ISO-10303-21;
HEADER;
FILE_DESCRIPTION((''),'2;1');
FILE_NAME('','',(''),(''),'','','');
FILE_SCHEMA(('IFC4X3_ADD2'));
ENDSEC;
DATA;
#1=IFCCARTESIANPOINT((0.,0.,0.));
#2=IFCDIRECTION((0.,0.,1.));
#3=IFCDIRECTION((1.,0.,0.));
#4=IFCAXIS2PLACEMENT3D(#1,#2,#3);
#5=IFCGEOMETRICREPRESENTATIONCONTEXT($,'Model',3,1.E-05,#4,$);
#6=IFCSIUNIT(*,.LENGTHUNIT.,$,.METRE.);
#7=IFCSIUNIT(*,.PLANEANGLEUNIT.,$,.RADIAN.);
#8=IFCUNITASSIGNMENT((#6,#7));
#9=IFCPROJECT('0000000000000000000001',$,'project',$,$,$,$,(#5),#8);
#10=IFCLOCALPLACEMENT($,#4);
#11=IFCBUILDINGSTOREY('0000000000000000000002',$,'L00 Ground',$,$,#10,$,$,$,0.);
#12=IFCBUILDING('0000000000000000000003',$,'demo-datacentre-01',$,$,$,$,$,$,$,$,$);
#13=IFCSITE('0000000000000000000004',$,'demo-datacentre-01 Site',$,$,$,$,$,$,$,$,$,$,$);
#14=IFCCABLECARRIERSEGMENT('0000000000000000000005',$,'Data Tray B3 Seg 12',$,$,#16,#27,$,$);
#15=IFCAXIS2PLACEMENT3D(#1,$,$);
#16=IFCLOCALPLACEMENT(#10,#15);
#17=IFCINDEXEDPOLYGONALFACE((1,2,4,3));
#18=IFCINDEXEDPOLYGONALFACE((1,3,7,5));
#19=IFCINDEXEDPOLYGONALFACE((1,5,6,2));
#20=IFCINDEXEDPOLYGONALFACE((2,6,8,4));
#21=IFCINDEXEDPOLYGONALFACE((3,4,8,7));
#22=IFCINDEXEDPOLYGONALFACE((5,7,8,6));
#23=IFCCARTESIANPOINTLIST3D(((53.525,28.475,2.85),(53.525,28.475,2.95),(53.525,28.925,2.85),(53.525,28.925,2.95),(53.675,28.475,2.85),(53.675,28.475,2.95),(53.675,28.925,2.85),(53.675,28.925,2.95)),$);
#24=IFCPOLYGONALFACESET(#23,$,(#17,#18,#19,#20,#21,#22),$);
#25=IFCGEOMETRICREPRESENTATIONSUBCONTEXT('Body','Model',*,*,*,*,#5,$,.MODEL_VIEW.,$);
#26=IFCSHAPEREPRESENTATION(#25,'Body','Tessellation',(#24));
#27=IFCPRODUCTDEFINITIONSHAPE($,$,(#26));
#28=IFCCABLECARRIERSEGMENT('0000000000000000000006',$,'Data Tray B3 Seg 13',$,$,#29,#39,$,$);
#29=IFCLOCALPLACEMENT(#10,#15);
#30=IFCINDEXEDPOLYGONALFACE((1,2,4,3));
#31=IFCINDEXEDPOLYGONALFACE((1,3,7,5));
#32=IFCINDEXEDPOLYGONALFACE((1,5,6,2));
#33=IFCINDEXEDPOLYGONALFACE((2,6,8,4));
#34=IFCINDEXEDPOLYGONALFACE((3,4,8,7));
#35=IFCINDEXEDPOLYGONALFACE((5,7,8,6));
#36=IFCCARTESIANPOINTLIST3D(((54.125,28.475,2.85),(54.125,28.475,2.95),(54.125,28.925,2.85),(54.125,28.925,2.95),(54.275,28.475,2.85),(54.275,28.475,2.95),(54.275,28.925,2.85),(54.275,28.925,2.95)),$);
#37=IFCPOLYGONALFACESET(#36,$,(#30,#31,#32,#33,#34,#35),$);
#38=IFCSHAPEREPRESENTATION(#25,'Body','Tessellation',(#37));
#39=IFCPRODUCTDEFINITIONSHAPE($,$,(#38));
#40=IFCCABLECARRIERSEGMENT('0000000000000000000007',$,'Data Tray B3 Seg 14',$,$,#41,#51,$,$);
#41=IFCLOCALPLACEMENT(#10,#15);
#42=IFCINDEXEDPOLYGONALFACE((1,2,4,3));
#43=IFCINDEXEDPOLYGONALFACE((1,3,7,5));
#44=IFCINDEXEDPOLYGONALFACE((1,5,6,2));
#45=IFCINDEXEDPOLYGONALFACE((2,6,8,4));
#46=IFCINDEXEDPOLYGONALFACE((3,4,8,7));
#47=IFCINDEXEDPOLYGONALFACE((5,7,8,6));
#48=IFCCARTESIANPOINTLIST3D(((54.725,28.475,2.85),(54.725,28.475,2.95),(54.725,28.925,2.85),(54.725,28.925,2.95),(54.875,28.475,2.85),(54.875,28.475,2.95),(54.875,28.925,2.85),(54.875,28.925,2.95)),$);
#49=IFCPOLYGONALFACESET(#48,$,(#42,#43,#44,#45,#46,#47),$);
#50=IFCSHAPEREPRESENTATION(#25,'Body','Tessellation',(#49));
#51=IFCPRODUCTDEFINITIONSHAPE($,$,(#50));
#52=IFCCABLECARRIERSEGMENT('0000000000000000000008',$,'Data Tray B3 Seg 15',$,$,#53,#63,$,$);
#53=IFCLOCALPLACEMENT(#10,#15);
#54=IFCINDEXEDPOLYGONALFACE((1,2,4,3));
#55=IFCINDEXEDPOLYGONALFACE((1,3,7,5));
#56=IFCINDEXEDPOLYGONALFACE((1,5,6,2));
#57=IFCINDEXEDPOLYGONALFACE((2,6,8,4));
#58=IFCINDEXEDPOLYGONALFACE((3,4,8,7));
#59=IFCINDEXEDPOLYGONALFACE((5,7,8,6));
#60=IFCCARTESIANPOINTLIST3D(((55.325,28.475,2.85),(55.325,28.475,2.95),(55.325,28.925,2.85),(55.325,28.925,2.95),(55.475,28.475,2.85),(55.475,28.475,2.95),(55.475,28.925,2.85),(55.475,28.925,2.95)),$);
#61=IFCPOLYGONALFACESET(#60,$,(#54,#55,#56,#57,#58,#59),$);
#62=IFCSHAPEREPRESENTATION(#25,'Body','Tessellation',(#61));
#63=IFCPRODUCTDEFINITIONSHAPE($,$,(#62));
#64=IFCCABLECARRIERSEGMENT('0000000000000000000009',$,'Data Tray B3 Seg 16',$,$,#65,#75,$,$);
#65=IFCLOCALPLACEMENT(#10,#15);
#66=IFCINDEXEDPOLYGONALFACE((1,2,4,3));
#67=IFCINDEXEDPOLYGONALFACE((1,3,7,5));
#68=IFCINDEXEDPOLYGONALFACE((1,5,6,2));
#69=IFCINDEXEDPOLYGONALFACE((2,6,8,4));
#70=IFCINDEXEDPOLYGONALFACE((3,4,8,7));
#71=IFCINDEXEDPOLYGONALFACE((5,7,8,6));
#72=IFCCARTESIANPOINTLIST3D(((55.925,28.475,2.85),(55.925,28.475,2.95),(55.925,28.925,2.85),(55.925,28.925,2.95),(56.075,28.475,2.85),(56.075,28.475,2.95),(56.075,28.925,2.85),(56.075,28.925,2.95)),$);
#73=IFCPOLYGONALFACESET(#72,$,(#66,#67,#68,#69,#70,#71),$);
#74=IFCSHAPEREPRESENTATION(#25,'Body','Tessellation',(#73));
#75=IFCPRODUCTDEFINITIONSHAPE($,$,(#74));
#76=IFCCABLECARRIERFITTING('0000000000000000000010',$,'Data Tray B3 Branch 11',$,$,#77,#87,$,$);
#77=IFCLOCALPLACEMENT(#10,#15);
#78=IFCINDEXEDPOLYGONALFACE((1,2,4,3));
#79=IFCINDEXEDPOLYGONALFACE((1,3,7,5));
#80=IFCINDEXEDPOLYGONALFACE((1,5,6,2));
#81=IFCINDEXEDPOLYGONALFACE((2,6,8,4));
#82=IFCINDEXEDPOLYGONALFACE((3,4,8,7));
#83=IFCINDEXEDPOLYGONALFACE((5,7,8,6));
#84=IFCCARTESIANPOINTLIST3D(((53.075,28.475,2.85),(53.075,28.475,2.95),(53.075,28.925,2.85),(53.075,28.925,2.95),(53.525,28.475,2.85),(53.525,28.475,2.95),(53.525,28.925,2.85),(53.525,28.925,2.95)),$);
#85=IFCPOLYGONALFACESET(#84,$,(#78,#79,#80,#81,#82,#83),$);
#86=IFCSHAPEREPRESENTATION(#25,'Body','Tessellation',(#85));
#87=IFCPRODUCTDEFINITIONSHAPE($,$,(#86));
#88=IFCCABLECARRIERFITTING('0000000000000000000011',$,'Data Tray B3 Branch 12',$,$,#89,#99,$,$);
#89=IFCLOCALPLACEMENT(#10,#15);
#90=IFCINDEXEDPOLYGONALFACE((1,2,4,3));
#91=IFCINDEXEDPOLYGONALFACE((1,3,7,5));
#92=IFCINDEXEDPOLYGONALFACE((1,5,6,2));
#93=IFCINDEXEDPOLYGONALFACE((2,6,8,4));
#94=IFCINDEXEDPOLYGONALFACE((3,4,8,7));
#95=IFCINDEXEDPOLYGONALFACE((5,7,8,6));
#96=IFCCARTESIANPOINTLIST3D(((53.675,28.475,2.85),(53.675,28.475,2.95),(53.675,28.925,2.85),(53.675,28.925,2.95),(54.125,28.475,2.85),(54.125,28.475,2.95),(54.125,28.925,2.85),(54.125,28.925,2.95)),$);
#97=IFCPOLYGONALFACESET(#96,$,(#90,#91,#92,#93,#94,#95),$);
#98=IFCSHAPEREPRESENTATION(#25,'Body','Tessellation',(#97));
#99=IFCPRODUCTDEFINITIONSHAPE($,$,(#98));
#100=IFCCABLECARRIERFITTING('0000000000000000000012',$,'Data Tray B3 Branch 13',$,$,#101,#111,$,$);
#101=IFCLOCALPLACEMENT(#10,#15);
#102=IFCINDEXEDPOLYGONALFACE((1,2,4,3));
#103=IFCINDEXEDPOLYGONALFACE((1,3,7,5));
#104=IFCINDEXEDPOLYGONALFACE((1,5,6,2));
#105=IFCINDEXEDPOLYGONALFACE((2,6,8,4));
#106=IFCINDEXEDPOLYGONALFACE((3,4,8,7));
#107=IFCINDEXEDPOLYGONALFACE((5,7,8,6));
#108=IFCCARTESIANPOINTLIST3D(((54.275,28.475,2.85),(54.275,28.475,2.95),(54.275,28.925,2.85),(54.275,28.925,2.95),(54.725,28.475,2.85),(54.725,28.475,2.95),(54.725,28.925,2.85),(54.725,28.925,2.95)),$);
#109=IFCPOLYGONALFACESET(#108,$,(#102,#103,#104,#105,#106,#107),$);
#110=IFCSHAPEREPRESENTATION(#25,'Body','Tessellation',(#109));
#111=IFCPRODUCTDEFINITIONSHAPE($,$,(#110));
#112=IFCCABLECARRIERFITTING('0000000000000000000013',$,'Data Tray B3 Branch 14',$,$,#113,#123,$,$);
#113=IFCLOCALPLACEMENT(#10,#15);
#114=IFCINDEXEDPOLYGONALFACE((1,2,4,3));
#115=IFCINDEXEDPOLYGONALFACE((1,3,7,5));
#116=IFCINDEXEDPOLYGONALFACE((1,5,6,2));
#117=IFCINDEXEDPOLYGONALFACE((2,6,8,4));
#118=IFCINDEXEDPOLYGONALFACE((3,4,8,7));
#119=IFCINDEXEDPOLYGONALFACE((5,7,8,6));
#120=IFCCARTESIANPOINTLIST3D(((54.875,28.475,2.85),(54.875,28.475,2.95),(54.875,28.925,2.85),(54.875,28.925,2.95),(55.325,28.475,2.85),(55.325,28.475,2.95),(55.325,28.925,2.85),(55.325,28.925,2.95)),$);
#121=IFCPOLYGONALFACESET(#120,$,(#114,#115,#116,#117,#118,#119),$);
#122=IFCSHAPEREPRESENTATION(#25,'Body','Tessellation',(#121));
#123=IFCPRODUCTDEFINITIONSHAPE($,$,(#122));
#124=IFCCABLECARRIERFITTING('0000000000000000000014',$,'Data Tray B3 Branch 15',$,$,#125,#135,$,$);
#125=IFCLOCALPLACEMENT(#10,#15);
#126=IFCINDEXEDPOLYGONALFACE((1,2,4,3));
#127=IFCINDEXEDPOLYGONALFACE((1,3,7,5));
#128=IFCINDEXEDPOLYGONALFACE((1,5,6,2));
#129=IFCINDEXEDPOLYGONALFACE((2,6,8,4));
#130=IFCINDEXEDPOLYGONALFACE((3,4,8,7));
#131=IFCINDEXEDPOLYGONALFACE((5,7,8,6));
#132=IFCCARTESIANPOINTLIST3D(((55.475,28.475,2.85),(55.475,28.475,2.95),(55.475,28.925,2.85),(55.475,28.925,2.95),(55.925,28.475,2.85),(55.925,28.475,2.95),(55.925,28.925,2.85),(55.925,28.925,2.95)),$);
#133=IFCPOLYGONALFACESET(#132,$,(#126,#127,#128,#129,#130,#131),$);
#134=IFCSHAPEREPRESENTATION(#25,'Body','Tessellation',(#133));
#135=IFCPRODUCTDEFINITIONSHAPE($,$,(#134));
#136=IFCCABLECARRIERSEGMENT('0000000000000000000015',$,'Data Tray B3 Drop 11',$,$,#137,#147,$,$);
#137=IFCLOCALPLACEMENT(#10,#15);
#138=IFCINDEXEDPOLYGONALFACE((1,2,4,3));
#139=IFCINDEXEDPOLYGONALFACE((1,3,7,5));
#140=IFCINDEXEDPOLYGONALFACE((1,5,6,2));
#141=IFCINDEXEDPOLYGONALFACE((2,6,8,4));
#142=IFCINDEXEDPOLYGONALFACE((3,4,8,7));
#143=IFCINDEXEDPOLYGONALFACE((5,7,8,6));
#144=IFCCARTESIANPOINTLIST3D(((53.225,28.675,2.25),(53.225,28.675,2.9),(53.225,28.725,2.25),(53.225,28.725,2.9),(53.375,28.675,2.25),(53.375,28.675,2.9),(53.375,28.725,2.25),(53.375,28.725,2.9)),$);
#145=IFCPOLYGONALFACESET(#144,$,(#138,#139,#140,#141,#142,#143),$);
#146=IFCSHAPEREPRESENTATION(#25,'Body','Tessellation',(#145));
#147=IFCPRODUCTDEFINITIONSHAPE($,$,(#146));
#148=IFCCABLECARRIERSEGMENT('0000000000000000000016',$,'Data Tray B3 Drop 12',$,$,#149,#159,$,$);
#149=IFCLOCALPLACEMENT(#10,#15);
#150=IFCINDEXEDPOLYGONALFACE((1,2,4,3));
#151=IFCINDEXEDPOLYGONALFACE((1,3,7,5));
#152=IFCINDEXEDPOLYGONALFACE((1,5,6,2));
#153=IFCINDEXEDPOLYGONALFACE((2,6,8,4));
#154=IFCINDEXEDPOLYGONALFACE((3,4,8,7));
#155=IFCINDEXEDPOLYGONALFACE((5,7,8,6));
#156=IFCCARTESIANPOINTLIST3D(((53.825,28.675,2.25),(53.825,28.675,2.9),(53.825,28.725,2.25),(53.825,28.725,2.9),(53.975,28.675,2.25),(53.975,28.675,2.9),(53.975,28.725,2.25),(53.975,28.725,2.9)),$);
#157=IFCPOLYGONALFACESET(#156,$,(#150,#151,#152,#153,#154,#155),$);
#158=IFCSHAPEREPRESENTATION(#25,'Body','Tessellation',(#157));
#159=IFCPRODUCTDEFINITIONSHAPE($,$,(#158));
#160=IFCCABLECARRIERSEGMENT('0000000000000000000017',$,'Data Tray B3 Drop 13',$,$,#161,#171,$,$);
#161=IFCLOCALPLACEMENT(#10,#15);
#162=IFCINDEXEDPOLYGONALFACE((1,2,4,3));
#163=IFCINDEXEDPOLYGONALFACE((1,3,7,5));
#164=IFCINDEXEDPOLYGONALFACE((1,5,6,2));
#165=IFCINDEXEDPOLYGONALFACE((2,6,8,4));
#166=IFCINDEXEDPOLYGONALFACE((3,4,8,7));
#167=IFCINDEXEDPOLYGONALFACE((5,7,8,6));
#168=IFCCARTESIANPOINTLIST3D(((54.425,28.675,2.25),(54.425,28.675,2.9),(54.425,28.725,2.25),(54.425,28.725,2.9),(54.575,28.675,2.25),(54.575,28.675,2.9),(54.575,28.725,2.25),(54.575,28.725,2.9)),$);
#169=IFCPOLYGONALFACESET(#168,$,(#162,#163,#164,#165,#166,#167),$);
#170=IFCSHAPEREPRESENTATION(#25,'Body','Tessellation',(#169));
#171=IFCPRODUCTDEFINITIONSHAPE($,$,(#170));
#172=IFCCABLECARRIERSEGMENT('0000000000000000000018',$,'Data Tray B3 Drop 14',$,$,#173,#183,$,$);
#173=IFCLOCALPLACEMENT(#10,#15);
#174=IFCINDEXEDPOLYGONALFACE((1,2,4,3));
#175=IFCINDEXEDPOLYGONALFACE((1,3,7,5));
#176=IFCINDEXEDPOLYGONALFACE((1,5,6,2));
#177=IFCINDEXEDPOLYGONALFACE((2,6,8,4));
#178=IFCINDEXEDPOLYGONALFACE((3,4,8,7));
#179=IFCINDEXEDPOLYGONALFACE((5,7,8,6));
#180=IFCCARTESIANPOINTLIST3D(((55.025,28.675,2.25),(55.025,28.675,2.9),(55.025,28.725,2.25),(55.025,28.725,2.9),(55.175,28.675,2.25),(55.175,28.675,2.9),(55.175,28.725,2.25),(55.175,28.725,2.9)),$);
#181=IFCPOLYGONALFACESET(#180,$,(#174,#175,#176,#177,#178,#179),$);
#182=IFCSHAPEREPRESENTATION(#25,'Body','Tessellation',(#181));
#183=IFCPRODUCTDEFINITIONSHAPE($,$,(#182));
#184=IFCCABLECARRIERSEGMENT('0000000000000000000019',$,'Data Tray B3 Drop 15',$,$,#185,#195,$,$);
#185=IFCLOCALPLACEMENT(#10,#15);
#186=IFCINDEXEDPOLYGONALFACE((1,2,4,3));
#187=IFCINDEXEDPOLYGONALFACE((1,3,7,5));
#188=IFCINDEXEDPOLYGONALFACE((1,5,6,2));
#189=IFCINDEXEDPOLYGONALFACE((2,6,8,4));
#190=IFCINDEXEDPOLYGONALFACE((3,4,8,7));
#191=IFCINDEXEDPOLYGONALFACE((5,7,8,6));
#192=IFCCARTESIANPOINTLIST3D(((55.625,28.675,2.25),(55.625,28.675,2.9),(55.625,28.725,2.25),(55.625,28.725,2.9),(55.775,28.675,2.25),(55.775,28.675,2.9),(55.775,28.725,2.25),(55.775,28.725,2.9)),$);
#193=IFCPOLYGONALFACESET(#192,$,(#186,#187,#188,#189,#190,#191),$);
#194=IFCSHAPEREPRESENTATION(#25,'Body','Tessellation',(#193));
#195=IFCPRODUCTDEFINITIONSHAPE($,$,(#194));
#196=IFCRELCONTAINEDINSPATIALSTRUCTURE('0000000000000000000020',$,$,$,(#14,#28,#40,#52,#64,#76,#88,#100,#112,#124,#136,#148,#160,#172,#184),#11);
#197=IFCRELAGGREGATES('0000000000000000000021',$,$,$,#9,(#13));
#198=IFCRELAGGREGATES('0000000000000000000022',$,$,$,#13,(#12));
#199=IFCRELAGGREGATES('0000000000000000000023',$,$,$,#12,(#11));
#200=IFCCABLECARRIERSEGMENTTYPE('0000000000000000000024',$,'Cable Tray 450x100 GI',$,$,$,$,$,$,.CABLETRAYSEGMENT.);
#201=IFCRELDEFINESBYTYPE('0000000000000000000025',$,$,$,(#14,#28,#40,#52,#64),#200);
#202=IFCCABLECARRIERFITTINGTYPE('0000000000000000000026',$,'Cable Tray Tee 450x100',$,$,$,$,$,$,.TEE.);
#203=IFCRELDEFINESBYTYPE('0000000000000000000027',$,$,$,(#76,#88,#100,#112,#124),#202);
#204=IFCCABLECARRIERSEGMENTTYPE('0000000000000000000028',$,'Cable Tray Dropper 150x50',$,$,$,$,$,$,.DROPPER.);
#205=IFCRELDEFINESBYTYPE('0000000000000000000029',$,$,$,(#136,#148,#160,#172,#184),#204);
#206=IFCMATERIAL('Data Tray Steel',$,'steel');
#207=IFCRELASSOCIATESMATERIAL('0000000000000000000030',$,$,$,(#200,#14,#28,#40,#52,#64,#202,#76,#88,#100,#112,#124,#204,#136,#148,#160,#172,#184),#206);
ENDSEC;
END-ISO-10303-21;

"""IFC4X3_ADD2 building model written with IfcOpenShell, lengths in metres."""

from ifc_helpers import new_model, si_unit, frame, origin_with_axes, place, context, subcontext, project, spatial, rectangle, extrude, material, type_object, element, save


model = new_model("IFC4X3_ADD2")

# Units and contexts
model_context = context("Model", 3, precision=1e-05, world=origin_with_axes())
body_context = subcontext(model_context, "Body", "Model", "MODEL_VIEW")
ifc_project = project(units=[si_unit("LENGTHUNIT", "METRE"), si_unit("PLANEANGLEUNIT", "RADIAN")], contexts=[model_context])

# Site, building, storey
site = spatial("IfcSite", under=ifc_project, Name="demo-datacentre-01 Site")
building = spatial("IfcBuilding", under=site, Name="demo-datacentre-01")
storey_placement = place(None, origin_with_axes())
storey = spatial("IfcBuildingStorey", under=building, at=storey_placement, Name="L00 Ground", Elevation=0.0)

# Cable carrier segments
ifc_material_1 = material(Name="Data Tray Steel", Category="steel")
cable_carrier_segment_type_1 = type_object("IfcCableCarrierSegmentType", Name="Cable Tray 450x100 GI", PredefinedType="CABLETRAYSEGMENT", material=ifc_material_1)
for number, where, z_axis, x_axis, name in (
    (1, (53.525, 28.7, 2.9), (1.0, 0.0, 0.0), (0.0, 1.0, 0.0), "Data Tray B3 Seg 12"),
    (2, (54.125, 28.7, 2.9), (1.0, 0.0, 0.0), (0.0, 1.0, 0.0), "Data Tray B3 Seg 13"),
):
    element("IfcCableCarrierSegment", number, at=place(storey_placement, frame(where, z_axis=z_axis, x_axis=x_axis)), inside=storey, type_object=cable_carrier_segment_type_1, material=ifc_material_1, Name=name, context=body_context, shape_type="SweptSolid", body=[
        extrude(rectangle(XDim=0.45, YDim=0.1), origin_with_axes(), (0.0, 0.0, 1.0), 0.15),
    ])
cable_carrier_segment_placement = place(storey_placement, frame((54.725, 28.7, 2.9), z_axis=(1.0, 0.0, 0.0), x_axis=(0.0, 1.0, 0.0)))
element("IfcCableCarrierSegment", 3, at=cable_carrier_segment_placement, inside=storey, type_object=cable_carrier_segment_type_1, material=ifc_material_1, Name="Data Tray B3 Seg 14", context=body_context, shape_type="SweptSolid", body=[
    extrude(rectangle(XDim=0.45, YDim=0.1), origin_with_axes(), (0.0, 0.0, 1.0), 0.15),
])
for number, where, z_axis, x_axis, name in (
    (4, (55.325, 28.7, 2.9), (1.0, 0.0, 0.0), (0.0, 1.0, 0.0), "Data Tray B3 Seg 15"),
    (5, (55.925, 28.7, 2.9), (1.0, 0.0, 0.0), (0.0, 1.0, 0.0), "Data Tray B3 Seg 16"),
):
    element("IfcCableCarrierSegment", number, at=place(storey_placement, frame(where, z_axis=z_axis, x_axis=x_axis)), inside=storey, type_object=cable_carrier_segment_type_1, material=ifc_material_1, Name=name, context=body_context, shape_type="SweptSolid", body=[
        extrude(rectangle(XDim=0.45, YDim=0.1), origin_with_axes(), (0.0, 0.0, 1.0), 0.15),
    ])

# Cable carrier fittings
cable_carrier_fitting_type = type_object("IfcCableCarrierFittingType", Name="Cable Tray Tee 450x100", PredefinedType="TEE", material=ifc_material_1)
for number, where, z_axis, x_axis, name in (
    (6, (53.3, 28.7, 2.85), (0.0, 0.0, 1.0), (1.0, 0.0, 0.0), "Data Tray B3 Branch 11"),
    (7, (53.9, 28.7, 2.85), (0.0, 0.0, 1.0), (1.0, 0.0, 0.0), "Data Tray B3 Branch 12"),
    (8, (54.5, 28.7, 2.85), (0.0, 0.0, 1.0), (1.0, 0.0, 0.0), "Data Tray B3 Branch 13"),
    (9, (55.1, 28.7, 2.85), (0.0, 0.0, 1.0), (1.0, 0.0, 0.0), "Data Tray B3 Branch 14"),
    (10, (55.7, 28.7, 2.85), (0.0, 0.0, 1.0), (1.0, 0.0, 0.0), "Data Tray B3 Branch 15"),
):
    element("IfcCableCarrierFitting", number, at=place(storey_placement, frame(where, z_axis=z_axis, x_axis=x_axis)), inside=storey, type_object=cable_carrier_fitting_type, material=ifc_material_1, Name=name, context=body_context, shape_type="SweptSolid", body=[
        extrude(rectangle(XDim=0.45, YDim=0.45), origin_with_axes(), (0.0, 0.0, 1.0), 0.1),
    ])

# Cable carrier segments
cable_carrier_segment_type_2 = type_object("IfcCableCarrierSegmentType", Name="Cable Tray Dropper 150x50", PredefinedType="DROPPER", material=ifc_material_1)
for number, where, z_axis, x_axis, name in (
    (11, (53.3, 28.7, 2.9), (0.0, 0.0, -1.0), (1.0, 0.0, 0.0), "Data Tray B3 Drop 11"),
    (12, (53.9, 28.7, 2.9), (0.0, 0.0, -1.0), (1.0, 0.0, 0.0), "Data Tray B3 Drop 12"),
    (13, (54.5, 28.7, 2.9), (0.0, 0.0, -1.0), (1.0, 0.0, 0.0), "Data Tray B3 Drop 13"),
    (14, (55.1, 28.7, 2.9), (0.0, 0.0, -1.0), (1.0, 0.0, 0.0), "Data Tray B3 Drop 14"),
    (15, (55.7, 28.7, 2.9), (0.0, 0.0, -1.0), (1.0, 0.0, 0.0), "Data Tray B3 Drop 15"),
):
    element("IfcCableCarrierSegment", number, at=place(storey_placement, frame(where, z_axis=z_axis, x_axis=x_axis)), inside=storey, type_object=cable_carrier_segment_type_2, material=ifc_material_1, Name=name, context=body_context, shape_type="SweptSolid", body=[
        extrude(rectangle(XDim=0.15, YDim=0.05), origin_with_axes(), (0.0, 0.0, 1.0), 0.65),
    ])

save(model, "model.ifc")
